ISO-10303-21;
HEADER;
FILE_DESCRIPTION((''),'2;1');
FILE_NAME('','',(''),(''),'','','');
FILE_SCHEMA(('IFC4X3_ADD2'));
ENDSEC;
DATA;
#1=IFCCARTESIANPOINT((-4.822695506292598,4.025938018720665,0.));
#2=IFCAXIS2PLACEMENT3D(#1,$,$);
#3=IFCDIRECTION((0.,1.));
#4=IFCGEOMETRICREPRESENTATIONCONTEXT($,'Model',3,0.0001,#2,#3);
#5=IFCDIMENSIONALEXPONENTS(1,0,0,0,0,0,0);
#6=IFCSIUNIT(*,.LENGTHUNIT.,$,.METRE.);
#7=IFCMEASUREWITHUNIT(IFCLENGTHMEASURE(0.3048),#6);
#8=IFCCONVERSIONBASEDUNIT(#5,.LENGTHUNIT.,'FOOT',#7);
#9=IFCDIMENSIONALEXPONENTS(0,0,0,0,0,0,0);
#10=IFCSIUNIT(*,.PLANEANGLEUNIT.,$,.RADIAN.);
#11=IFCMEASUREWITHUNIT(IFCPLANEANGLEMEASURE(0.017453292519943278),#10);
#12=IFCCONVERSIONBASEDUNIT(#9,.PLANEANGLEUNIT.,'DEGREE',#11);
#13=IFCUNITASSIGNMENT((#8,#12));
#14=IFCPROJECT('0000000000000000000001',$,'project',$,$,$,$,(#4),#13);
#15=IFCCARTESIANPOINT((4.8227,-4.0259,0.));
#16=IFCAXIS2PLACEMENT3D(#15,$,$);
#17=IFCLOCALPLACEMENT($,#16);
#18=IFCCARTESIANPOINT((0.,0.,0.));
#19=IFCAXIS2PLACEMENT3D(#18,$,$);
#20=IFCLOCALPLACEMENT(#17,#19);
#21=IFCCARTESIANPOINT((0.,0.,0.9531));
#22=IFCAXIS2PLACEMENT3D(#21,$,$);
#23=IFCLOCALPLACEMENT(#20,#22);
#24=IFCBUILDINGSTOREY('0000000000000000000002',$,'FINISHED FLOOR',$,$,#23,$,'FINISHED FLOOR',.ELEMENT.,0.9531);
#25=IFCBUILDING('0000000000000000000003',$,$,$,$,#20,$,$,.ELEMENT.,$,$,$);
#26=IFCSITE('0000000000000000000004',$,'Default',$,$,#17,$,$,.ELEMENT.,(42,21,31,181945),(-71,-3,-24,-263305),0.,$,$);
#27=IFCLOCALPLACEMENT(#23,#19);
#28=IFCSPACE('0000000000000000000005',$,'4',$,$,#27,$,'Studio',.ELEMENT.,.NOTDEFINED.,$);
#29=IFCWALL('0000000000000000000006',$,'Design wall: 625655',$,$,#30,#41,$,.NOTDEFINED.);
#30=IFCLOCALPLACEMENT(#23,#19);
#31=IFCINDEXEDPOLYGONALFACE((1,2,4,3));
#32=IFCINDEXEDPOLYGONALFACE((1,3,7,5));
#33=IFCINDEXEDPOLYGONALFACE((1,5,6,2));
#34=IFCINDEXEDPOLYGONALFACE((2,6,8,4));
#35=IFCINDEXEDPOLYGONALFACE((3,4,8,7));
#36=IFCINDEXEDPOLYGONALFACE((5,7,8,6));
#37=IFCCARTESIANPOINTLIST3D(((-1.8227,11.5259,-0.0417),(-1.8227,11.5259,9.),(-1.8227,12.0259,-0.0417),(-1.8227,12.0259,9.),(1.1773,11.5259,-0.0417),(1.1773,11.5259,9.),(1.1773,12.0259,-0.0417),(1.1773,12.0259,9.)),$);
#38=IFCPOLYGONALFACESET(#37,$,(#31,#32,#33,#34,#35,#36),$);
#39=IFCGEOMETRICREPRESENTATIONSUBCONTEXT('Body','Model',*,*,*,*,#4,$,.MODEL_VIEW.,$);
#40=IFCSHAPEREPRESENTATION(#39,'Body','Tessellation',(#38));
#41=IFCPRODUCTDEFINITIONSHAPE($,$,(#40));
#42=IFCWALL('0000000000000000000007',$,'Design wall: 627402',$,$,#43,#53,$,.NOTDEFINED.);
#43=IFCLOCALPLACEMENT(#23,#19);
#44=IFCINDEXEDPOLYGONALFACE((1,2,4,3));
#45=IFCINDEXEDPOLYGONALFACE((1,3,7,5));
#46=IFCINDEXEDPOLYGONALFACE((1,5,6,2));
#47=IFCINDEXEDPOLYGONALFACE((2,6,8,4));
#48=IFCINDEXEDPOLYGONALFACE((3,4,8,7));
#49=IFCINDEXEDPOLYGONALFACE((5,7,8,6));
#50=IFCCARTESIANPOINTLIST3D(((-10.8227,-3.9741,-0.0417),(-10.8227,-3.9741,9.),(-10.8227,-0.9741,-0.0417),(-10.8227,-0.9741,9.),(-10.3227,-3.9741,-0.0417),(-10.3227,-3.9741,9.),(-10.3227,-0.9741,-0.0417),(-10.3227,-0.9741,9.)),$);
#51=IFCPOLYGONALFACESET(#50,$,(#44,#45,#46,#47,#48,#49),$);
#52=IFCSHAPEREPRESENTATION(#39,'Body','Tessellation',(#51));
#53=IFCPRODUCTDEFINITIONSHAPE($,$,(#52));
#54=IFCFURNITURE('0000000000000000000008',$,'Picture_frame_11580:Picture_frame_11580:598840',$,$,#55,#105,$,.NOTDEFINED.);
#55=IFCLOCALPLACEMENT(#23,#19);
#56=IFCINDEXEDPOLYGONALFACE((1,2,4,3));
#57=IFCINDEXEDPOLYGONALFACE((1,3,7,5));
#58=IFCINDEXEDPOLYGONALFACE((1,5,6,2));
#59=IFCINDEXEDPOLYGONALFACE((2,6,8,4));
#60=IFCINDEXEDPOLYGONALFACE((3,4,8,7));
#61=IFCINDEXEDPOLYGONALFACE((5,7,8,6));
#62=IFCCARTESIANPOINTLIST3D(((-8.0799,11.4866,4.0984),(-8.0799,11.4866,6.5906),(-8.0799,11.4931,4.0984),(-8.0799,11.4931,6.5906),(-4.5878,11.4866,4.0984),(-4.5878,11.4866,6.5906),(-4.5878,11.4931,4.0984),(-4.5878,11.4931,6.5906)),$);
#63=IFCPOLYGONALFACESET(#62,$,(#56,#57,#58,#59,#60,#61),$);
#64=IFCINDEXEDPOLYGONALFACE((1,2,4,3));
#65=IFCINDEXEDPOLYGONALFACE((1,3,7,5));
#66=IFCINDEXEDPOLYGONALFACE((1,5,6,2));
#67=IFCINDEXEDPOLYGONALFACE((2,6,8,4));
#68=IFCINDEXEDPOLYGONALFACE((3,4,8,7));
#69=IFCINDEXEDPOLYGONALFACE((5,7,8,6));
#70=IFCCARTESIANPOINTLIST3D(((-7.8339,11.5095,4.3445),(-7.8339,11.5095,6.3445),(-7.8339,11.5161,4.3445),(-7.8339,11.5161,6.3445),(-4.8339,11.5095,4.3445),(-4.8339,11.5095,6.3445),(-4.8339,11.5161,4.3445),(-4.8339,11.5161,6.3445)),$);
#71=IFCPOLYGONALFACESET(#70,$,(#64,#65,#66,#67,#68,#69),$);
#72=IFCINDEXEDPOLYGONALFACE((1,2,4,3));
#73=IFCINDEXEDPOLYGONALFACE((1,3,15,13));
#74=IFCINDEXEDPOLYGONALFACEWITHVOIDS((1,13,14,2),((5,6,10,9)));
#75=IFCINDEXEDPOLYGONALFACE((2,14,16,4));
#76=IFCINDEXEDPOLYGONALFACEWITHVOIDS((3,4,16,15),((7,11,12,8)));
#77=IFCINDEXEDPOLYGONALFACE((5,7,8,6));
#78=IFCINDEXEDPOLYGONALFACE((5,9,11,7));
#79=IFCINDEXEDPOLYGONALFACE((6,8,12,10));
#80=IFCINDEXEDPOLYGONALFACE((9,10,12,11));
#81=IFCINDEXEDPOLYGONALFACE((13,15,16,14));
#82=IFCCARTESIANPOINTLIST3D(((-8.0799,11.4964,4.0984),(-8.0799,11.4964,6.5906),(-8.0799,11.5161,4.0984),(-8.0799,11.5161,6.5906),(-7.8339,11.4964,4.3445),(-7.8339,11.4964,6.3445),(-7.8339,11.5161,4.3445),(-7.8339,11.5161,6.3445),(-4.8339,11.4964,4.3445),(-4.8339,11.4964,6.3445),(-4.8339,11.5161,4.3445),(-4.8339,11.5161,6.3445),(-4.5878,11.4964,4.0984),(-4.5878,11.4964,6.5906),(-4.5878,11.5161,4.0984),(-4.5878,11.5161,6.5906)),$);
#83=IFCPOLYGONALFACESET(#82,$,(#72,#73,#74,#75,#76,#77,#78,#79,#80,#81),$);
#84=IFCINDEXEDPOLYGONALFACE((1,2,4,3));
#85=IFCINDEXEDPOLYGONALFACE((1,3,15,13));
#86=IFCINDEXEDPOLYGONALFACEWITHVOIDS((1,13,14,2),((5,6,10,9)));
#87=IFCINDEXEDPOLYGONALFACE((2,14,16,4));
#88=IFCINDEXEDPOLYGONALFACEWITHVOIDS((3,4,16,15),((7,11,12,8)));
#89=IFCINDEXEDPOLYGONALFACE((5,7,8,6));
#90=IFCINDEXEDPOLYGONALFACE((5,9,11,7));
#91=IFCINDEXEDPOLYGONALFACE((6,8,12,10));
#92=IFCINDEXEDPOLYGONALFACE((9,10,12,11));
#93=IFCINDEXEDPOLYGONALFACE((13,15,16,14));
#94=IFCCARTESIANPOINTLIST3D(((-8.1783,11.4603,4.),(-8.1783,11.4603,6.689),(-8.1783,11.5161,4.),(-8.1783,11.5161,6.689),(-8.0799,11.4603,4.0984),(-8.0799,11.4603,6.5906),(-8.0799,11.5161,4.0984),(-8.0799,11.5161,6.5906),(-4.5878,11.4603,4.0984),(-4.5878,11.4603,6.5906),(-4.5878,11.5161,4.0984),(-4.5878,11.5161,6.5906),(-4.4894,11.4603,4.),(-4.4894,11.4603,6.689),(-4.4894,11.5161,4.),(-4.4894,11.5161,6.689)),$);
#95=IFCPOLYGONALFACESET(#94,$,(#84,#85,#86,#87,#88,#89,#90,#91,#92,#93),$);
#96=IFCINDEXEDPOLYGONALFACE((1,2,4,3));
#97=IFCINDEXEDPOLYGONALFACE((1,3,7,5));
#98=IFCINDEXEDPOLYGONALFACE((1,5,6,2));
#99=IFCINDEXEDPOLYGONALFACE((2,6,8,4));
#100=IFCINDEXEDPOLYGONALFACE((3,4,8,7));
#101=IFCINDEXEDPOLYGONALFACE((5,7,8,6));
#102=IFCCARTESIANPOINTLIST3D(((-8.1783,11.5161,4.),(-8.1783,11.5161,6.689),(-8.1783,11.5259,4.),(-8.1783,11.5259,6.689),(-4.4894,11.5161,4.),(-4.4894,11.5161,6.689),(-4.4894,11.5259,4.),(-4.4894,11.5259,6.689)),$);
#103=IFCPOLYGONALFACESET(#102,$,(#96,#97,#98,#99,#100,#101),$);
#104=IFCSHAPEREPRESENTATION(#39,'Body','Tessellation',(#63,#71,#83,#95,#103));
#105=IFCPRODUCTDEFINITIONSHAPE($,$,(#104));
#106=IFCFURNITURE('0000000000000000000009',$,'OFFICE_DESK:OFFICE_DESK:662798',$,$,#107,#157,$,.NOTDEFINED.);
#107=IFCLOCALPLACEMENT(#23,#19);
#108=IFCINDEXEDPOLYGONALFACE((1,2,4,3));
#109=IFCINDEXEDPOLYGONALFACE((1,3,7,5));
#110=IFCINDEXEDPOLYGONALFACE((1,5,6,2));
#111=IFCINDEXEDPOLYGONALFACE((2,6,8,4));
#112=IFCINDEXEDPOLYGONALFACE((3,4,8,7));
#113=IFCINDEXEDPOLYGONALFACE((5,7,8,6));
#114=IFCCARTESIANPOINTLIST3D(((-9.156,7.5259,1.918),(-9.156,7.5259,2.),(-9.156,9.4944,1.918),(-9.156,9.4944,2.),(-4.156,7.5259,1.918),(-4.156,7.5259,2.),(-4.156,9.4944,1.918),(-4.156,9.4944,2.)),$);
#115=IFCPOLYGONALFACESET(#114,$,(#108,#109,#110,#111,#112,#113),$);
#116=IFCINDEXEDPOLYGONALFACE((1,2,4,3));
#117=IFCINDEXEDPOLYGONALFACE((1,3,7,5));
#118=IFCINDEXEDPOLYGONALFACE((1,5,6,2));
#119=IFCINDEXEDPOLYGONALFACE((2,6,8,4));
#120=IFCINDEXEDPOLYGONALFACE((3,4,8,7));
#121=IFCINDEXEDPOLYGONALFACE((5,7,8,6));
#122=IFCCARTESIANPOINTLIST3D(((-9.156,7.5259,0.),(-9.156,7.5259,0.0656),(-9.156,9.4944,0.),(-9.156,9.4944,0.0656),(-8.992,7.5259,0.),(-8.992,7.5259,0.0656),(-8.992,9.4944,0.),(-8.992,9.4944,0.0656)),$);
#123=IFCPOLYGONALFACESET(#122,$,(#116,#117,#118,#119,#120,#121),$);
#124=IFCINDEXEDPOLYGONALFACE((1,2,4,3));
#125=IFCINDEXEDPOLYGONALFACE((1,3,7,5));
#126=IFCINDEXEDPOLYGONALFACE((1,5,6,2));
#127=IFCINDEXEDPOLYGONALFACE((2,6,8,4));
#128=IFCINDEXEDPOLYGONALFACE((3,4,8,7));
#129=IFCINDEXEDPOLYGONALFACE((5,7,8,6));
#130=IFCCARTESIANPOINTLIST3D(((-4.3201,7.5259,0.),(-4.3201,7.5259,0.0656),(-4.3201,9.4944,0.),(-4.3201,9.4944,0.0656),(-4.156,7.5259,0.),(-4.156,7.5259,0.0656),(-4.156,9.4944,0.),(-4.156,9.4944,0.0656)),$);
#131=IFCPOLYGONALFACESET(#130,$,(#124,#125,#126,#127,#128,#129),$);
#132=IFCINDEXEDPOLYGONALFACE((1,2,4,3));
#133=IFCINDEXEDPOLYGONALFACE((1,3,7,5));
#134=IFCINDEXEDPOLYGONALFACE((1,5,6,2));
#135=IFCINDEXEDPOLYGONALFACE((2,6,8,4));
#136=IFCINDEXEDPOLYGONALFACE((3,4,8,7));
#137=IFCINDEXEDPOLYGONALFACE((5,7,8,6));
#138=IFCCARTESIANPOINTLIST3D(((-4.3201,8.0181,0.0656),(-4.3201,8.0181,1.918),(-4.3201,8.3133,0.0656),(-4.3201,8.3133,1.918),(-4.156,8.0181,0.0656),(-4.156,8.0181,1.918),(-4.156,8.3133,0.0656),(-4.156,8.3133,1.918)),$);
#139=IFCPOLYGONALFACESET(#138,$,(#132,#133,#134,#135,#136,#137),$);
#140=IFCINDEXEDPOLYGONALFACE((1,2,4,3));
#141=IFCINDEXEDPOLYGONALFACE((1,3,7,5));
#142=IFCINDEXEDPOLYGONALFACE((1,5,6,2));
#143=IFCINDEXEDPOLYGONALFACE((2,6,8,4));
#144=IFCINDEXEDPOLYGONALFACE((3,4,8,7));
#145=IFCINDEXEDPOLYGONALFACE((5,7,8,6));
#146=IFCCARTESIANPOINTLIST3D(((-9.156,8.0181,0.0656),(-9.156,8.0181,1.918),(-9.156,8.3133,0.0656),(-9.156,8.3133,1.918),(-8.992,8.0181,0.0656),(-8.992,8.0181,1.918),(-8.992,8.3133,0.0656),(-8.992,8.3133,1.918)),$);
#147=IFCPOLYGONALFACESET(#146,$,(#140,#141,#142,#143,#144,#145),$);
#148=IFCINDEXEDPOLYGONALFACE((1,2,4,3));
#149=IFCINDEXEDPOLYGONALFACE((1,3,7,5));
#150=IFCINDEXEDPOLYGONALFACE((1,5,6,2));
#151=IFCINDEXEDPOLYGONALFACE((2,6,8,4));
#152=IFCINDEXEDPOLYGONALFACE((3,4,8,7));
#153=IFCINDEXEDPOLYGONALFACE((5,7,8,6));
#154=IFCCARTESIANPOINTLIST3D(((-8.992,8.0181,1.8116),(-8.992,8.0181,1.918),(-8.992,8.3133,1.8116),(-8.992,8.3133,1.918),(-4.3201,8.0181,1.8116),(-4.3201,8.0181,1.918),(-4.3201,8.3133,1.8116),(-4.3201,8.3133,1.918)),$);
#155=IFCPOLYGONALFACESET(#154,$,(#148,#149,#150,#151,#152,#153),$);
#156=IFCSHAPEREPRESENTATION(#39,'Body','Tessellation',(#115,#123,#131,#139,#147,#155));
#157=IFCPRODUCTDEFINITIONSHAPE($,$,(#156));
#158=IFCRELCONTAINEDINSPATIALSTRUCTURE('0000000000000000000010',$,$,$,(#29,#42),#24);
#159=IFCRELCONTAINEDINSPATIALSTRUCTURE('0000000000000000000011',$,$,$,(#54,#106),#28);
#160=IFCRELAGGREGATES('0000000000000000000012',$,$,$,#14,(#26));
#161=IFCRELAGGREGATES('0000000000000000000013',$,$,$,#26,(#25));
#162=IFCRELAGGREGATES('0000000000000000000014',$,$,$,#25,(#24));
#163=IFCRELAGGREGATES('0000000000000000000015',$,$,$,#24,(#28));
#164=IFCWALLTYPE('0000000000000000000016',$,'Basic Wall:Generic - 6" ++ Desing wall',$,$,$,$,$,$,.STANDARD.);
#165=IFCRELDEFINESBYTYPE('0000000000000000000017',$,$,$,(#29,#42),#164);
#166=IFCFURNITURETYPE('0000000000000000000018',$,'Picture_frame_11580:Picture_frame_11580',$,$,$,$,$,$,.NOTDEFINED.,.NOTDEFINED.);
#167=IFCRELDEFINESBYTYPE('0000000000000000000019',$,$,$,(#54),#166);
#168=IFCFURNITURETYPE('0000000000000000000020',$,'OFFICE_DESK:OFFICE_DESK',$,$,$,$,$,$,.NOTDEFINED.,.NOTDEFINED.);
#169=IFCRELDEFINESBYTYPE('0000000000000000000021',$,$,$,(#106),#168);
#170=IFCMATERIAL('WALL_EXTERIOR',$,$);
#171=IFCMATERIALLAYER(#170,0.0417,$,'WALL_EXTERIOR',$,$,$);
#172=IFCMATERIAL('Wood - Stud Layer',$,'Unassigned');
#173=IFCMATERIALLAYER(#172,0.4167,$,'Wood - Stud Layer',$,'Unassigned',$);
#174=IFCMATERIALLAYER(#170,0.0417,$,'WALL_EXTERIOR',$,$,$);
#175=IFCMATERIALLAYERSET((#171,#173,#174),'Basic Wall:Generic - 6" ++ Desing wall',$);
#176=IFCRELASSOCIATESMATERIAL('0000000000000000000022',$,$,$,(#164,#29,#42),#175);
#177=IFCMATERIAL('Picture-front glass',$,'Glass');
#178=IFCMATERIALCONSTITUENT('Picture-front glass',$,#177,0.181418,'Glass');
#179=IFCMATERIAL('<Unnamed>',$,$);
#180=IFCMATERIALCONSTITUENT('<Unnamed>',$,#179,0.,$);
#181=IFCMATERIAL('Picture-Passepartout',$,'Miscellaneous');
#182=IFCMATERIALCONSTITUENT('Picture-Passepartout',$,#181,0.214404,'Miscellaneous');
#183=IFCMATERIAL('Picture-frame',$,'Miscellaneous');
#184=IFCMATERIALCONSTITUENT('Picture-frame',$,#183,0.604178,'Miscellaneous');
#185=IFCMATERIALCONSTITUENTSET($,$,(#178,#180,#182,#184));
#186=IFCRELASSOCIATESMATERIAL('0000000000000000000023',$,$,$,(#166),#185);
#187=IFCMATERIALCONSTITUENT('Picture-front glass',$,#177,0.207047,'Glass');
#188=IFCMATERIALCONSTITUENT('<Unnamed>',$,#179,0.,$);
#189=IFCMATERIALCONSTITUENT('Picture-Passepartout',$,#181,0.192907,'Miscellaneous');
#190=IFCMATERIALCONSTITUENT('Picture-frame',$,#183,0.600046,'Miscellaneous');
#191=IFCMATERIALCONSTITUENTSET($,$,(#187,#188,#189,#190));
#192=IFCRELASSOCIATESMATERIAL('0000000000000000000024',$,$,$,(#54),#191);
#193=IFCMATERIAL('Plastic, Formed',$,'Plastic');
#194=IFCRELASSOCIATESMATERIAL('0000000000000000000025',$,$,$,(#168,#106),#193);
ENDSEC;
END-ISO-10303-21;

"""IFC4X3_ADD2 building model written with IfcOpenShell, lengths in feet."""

from ifc_helpers import new_model, entity, si_unit, converted_unit, direction, frame, frame_2d, origin, origin_2d_with_axis, place, context, subcontext, project, spatial, polyline, rectangle, outline, extrude, source, transform, mapped, material, layer, layer_set, constituent, constituent_set, type_object, type_shapes, element, save


model = new_model("IFC4X3_ADD2")

# Units and contexts
model_context = context("Model", 3, precision=0.0001, world=frame((-4.822695506292598, 4.025938018720665, 0.0)), true_north=direction((0.0, 1.0)))
body_context = subcontext(model_context, "Body", "Model", "MODEL_VIEW")
ifc_project = project(units=[converted_unit("LENGTHUNIT", "FOOT", entity("IfcLengthMeasure", 0.3048), si_unit("LENGTHUNIT", "METRE"), dimensions=[1, 0, 0, 0, 0, 0, 0]), converted_unit("PLANEANGLEUNIT", "DEGREE", entity("IfcPlaneAngleMeasure", 0.017453292519943278), si_unit("PLANEANGLEUNIT", "RADIAN"), dimensions=[0, 0, 0, 0, 0, 0, 0])], contexts=[model_context])

# Site, building, storey
site_placement = place(None, frame((4.8227, -4.0259, 0.0)))
site = spatial("IfcSite", under=ifc_project, at=site_placement, Name="Default", CompositionType="ELEMENT", RefLatitude=(42, 21, 31, 181945), RefLongitude=(-71, -3, -24, -263305), RefElevation=0.0)
building_placement = place(site_placement, origin())
building = spatial("IfcBuilding", under=site, at=building_placement, CompositionType="ELEMENT")
storey_placement = place(building_placement, frame((0.0, 0.0, 0.9531)))
storey = spatial("IfcBuildingStorey", under=building, at=storey_placement, Name="FINISHED FLOOR", LongName="FINISHED FLOOR", CompositionType="ELEMENT", Elevation=0.9531)

# Shared definitions
ifc_material_1 = material(Name="WALL_EXTERIOR")
ifc_material_2 = material(Name="Wood - Stud Layer", Category="Unassigned")

# Walls
ifc_layer_1 = layer(ifc_material_1, 0.0417, Name="WALL_EXTERIOR")
ifc_layer_2 = layer(ifc_material_2, 0.4167, Name="Wood - Stud Layer", Category="Unassigned")
ifc_layer_3 = layer(ifc_material_1, 0.0417, Name="WALL_EXTERIOR")
ifc_layer_set_1 = layer_set([ifc_layer_1, ifc_layer_2, ifc_layer_3], Name="Basic Wall:Generic - 6\" ++ Desing wall")
wall_type_1 = type_object("IfcWallType", Name="Basic Wall:Generic - 6\" ++ Desing wall", PredefinedType="STANDARD", material=ifc_layer_set_1)
wall_1_placement = place(storey_placement, frame((-1.8227, 11.7759, -0.0417)))
element("IfcWall", 1, at=wall_1_placement, inside=storey, type_object=wall_type_1, material=ifc_layer_set_1, Name="Design wall: 625655", PredefinedType="NOTDEFINED", context=body_context, shape_type="SweptSolid", body=[
    extrude(rectangle(XDim=3.0, YDim=0.5, at=frame_2d((1.5, 0.0), x_axis=(-1.0, 0.0))), origin(), (0.0, 0.0, 1.0), 9.0417),
])
wall_2_placement = place(storey_placement, frame((-10.5727, -0.9741, -0.0417), z_axis=(0.0, 0.0, 1.0), x_axis=(0.0, -1.0, 0.0)))
element("IfcWall", 2, at=wall_2_placement, inside=storey, type_object=wall_type_1, material=ifc_layer_set_1, Name="Design wall: 627402", PredefinedType="NOTDEFINED", context=body_context, shape_type="SweptSolid", body=[
    extrude(rectangle(XDim=3.0, YDim=0.5, at=frame_2d((1.5, 0.0), x_axis=(-1.0, 0.0))), origin(), (0.0, 0.0, 1.0), 9.0417),
])

# Shared definitions
space_placement = place(storey_placement, origin())
space = spatial("IfcSpace", under=storey, at=space_placement, Name="4", LongName="Studio", CompositionType="ELEMENT", PredefinedType="NOTDEFINED")

# Furniture
ifc_material_3 = material(Name="Picture-front glass", Category="Glass")
ifc_constituent_1 = constituent(ifc_material_3, Name="Picture-front glass", Category="Glass", fraction=0.207047)
ifc_material_4 = material(Name="<Unnamed>")
ifc_constituent_2 = constituent(ifc_material_4, Name="<Unnamed>", fraction=0.0)
ifc_material_5 = material(Name="Picture-Passepartout", Category="Miscellaneous")
ifc_constituent_3 = constituent(ifc_material_5, Name="Picture-Passepartout", Category="Miscellaneous", fraction=0.192907)
ifc_material_6 = material(Name="Picture-frame", Category="Miscellaneous")
ifc_constituent_4 = constituent(ifc_material_6, Name="Picture-frame", Category="Miscellaneous", fraction=0.600046)
ifc_constituent_set_1 = constituent_set(constituents=[ifc_constituent_1, ifc_constituent_2, ifc_constituent_3, ifc_constituent_4])
ifc_constituent_5 = constituent(ifc_material_3, Name="Picture-front glass", Category="Glass", fraction=0.181418)
ifc_constituent_6 = constituent(ifc_material_4, Name="<Unnamed>", fraction=0.0)
ifc_constituent_7 = constituent(ifc_material_5, Name="Picture-Passepartout", Category="Miscellaneous", fraction=0.214404)
ifc_constituent_8 = constituent(ifc_material_6, Name="Picture-frame", Category="Miscellaneous", fraction=0.604178)
ifc_constituent_set_2 = constituent_set(constituents=[ifc_constituent_5, ifc_constituent_6, ifc_constituent_7, ifc_constituent_8])
furniture_type_1 = type_object("IfcFurnitureType", Name="Picture_frame_11580:Picture_frame_11580", AssemblyPlace="NOTDEFINED", PredefinedType="NOTDEFINED", material=ifc_constituent_set_2)
shared_shape_1 = source(origin(), body_context, "Body", "SweptSolid", [
    extrude(rectangle(XDim=0.0066, YDim=3.4921, at=frame_2d((0.0, 0.0), x_axis=(1.0, 0.0))), frame((1.8445, -0.0361, 0.0984), z_axis=(0.0, 0.0, 1.0), x_axis=(0.0, 1.0, 0.0)), (0.0, 0.0, 1.0), 2.4921),
    extrude(rectangle(XDim=0.0066, YDim=3.0, at=origin_2d_with_axis()), frame((1.8445, -0.0131, 0.3445), z_axis=(0.0, 0.0, 1.0), x_axis=(0.0, 1.0, 0.0)), (0.0, 0.0, 1.0), 2.0),
    extrude(outline(polyline([(-1.2461, -1.7461), (1.2461, -1.7461), (1.2461, 1.7461), (-1.2461, 1.7461), (-1.2461, -1.7461)]), holes=[polyline([(-1.0, -1.5), (-1.0, 1.5), (1.0, 1.5), (1.0, -1.5), (-1.0, -1.5)])]), frame((1.8445, -0.0295, 1.3445), z_axis=(0.0, 1.0, 0.0), x_axis=(0.0, 0.0, -1.0)), (0.0, 0.0, 1.0), 0.0197),
    extrude(outline(polyline([(-1.8445, -1.3445), (1.8445, -1.3445), (1.8445, 1.3445), (-1.8445, 1.3445), (-1.8445, -1.3445)]), holes=[polyline([(1.7461, -1.2461), (-1.7461, -1.2461), (-1.7461, 1.2461), (1.7461, 1.2461), (1.7461, -1.2461)])]), frame((1.8445, -0.0656, 1.3445), z_axis=(0.0, 1.0, 0.0), x_axis=(1.0, 0.0, 0.0)), (0.0, 0.0, 1.0), 0.0558),
    extrude(rectangle(XDim=0.0098, YDim=3.689, at=origin_2d_with_axis()), frame((1.8445, -0.0049, 0.0), z_axis=(0.0, 0.0, 1.0), x_axis=(0.0, 1.0, 0.0)), (0.0, 0.0, 1.0), 2.689),
])
type_shapes(furniture_type_1, [shared_shape_1])
furniture_1_placement = place(space_placement, frame((-8.1783, 11.5259, 4.0)))
element("IfcFurniture", 3, at=furniture_1_placement, inside=space, type_object=furniture_type_1, material=ifc_constituent_set_1, Name="Picture_frame_11580:Picture_frame_11580:598840", PredefinedType="NOTDEFINED", context=body_context, shape_type="MappedRepresentation", body=[
    mapped(shared_shape_1, transform((0.0, 0.0, 0.0), scale=1.0)),
])
ifc_material_7 = material(Name="Plastic, Formed", Category="Plastic")
furniture_type_2 = type_object("IfcFurnitureType", Name="OFFICE_DESK:OFFICE_DESK", AssemblyPlace="NOTDEFINED", PredefinedType="NOTDEFINED", material=ifc_material_7)
shared_shape_2 = source(origin(), body_context, "Body", "SweptSolid", [
    extrude(rectangle(XDim=1.9685, YDim=5.0, at=origin_2d_with_axis()), frame((0.0, -0.9843, 1.918), z_axis=(0.0, 0.0, 1.0), x_axis=(0.0, -1.0, 0.0)), (0.0, 0.0, 1.0), 0.082),
    extrude(rectangle(XDim=0.164, YDim=1.9685, at=origin_2d_with_axis()), frame((2.418, -0.9843, 0.0)), (0.0, 0.0, 1.0), 0.0656),
    extrude(rectangle(XDim=1.9685, YDim=0.164, at=origin_2d_with_axis()), frame((-2.418, -0.9843, 0.0), z_axis=(0.0, 0.0, 1.0), x_axis=(0.0, 1.0, 0.0)), (0.0, 0.0, 1.0), 0.0656),
    extrude(rectangle(XDim=0.2953, YDim=0.164, at=frame_2d((0.0, 0.0), x_axis=(1.0, 0.0))), frame((-2.418, -0.6398, 0.0656), z_axis=(0.0, 0.0, 1.0), x_axis=(0.0, -1.0, 0.0)), (0.0, 0.0, 1.0), 1.8524),
    extrude(rectangle(XDim=0.164, YDim=0.2953, at=origin_2d_with_axis()), frame((2.418, -0.6398, 0.0656), z_axis=(0.0, 0.0, 1.0), x_axis=(-1.0, 0.0, 0.0)), (0.0, 0.0, 1.0), 1.8524),
    extrude(rectangle(XDim=0.2953, YDim=4.6719, at=origin_2d_with_axis()), frame((0.0, -0.6398, 1.8116), z_axis=(0.0, 0.0, 1.0), x_axis=(0.0, 1.0, 0.0)), (0.0, 0.0, 1.0), 0.1064),
])
type_shapes(furniture_type_2, [shared_shape_2])
furniture_2_placement = place(space_placement, frame((-6.656, 7.5259, 0.0), z_axis=(0.0, 0.0, 1.0), x_axis=(-1.0, 0.0, 0.0)))
element("IfcFurniture", 4, at=furniture_2_placement, inside=space, type_object=furniture_type_2, material=ifc_material_7, Name="OFFICE_DESK:OFFICE_DESK:662798", PredefinedType="NOTDEFINED", context=body_context, shape_type="MappedRepresentation", body=[
    mapped(shared_shape_2, transform((0.0, 0.0, 0.0), scale=1.0)),
])

save(model, "model.ifc")
